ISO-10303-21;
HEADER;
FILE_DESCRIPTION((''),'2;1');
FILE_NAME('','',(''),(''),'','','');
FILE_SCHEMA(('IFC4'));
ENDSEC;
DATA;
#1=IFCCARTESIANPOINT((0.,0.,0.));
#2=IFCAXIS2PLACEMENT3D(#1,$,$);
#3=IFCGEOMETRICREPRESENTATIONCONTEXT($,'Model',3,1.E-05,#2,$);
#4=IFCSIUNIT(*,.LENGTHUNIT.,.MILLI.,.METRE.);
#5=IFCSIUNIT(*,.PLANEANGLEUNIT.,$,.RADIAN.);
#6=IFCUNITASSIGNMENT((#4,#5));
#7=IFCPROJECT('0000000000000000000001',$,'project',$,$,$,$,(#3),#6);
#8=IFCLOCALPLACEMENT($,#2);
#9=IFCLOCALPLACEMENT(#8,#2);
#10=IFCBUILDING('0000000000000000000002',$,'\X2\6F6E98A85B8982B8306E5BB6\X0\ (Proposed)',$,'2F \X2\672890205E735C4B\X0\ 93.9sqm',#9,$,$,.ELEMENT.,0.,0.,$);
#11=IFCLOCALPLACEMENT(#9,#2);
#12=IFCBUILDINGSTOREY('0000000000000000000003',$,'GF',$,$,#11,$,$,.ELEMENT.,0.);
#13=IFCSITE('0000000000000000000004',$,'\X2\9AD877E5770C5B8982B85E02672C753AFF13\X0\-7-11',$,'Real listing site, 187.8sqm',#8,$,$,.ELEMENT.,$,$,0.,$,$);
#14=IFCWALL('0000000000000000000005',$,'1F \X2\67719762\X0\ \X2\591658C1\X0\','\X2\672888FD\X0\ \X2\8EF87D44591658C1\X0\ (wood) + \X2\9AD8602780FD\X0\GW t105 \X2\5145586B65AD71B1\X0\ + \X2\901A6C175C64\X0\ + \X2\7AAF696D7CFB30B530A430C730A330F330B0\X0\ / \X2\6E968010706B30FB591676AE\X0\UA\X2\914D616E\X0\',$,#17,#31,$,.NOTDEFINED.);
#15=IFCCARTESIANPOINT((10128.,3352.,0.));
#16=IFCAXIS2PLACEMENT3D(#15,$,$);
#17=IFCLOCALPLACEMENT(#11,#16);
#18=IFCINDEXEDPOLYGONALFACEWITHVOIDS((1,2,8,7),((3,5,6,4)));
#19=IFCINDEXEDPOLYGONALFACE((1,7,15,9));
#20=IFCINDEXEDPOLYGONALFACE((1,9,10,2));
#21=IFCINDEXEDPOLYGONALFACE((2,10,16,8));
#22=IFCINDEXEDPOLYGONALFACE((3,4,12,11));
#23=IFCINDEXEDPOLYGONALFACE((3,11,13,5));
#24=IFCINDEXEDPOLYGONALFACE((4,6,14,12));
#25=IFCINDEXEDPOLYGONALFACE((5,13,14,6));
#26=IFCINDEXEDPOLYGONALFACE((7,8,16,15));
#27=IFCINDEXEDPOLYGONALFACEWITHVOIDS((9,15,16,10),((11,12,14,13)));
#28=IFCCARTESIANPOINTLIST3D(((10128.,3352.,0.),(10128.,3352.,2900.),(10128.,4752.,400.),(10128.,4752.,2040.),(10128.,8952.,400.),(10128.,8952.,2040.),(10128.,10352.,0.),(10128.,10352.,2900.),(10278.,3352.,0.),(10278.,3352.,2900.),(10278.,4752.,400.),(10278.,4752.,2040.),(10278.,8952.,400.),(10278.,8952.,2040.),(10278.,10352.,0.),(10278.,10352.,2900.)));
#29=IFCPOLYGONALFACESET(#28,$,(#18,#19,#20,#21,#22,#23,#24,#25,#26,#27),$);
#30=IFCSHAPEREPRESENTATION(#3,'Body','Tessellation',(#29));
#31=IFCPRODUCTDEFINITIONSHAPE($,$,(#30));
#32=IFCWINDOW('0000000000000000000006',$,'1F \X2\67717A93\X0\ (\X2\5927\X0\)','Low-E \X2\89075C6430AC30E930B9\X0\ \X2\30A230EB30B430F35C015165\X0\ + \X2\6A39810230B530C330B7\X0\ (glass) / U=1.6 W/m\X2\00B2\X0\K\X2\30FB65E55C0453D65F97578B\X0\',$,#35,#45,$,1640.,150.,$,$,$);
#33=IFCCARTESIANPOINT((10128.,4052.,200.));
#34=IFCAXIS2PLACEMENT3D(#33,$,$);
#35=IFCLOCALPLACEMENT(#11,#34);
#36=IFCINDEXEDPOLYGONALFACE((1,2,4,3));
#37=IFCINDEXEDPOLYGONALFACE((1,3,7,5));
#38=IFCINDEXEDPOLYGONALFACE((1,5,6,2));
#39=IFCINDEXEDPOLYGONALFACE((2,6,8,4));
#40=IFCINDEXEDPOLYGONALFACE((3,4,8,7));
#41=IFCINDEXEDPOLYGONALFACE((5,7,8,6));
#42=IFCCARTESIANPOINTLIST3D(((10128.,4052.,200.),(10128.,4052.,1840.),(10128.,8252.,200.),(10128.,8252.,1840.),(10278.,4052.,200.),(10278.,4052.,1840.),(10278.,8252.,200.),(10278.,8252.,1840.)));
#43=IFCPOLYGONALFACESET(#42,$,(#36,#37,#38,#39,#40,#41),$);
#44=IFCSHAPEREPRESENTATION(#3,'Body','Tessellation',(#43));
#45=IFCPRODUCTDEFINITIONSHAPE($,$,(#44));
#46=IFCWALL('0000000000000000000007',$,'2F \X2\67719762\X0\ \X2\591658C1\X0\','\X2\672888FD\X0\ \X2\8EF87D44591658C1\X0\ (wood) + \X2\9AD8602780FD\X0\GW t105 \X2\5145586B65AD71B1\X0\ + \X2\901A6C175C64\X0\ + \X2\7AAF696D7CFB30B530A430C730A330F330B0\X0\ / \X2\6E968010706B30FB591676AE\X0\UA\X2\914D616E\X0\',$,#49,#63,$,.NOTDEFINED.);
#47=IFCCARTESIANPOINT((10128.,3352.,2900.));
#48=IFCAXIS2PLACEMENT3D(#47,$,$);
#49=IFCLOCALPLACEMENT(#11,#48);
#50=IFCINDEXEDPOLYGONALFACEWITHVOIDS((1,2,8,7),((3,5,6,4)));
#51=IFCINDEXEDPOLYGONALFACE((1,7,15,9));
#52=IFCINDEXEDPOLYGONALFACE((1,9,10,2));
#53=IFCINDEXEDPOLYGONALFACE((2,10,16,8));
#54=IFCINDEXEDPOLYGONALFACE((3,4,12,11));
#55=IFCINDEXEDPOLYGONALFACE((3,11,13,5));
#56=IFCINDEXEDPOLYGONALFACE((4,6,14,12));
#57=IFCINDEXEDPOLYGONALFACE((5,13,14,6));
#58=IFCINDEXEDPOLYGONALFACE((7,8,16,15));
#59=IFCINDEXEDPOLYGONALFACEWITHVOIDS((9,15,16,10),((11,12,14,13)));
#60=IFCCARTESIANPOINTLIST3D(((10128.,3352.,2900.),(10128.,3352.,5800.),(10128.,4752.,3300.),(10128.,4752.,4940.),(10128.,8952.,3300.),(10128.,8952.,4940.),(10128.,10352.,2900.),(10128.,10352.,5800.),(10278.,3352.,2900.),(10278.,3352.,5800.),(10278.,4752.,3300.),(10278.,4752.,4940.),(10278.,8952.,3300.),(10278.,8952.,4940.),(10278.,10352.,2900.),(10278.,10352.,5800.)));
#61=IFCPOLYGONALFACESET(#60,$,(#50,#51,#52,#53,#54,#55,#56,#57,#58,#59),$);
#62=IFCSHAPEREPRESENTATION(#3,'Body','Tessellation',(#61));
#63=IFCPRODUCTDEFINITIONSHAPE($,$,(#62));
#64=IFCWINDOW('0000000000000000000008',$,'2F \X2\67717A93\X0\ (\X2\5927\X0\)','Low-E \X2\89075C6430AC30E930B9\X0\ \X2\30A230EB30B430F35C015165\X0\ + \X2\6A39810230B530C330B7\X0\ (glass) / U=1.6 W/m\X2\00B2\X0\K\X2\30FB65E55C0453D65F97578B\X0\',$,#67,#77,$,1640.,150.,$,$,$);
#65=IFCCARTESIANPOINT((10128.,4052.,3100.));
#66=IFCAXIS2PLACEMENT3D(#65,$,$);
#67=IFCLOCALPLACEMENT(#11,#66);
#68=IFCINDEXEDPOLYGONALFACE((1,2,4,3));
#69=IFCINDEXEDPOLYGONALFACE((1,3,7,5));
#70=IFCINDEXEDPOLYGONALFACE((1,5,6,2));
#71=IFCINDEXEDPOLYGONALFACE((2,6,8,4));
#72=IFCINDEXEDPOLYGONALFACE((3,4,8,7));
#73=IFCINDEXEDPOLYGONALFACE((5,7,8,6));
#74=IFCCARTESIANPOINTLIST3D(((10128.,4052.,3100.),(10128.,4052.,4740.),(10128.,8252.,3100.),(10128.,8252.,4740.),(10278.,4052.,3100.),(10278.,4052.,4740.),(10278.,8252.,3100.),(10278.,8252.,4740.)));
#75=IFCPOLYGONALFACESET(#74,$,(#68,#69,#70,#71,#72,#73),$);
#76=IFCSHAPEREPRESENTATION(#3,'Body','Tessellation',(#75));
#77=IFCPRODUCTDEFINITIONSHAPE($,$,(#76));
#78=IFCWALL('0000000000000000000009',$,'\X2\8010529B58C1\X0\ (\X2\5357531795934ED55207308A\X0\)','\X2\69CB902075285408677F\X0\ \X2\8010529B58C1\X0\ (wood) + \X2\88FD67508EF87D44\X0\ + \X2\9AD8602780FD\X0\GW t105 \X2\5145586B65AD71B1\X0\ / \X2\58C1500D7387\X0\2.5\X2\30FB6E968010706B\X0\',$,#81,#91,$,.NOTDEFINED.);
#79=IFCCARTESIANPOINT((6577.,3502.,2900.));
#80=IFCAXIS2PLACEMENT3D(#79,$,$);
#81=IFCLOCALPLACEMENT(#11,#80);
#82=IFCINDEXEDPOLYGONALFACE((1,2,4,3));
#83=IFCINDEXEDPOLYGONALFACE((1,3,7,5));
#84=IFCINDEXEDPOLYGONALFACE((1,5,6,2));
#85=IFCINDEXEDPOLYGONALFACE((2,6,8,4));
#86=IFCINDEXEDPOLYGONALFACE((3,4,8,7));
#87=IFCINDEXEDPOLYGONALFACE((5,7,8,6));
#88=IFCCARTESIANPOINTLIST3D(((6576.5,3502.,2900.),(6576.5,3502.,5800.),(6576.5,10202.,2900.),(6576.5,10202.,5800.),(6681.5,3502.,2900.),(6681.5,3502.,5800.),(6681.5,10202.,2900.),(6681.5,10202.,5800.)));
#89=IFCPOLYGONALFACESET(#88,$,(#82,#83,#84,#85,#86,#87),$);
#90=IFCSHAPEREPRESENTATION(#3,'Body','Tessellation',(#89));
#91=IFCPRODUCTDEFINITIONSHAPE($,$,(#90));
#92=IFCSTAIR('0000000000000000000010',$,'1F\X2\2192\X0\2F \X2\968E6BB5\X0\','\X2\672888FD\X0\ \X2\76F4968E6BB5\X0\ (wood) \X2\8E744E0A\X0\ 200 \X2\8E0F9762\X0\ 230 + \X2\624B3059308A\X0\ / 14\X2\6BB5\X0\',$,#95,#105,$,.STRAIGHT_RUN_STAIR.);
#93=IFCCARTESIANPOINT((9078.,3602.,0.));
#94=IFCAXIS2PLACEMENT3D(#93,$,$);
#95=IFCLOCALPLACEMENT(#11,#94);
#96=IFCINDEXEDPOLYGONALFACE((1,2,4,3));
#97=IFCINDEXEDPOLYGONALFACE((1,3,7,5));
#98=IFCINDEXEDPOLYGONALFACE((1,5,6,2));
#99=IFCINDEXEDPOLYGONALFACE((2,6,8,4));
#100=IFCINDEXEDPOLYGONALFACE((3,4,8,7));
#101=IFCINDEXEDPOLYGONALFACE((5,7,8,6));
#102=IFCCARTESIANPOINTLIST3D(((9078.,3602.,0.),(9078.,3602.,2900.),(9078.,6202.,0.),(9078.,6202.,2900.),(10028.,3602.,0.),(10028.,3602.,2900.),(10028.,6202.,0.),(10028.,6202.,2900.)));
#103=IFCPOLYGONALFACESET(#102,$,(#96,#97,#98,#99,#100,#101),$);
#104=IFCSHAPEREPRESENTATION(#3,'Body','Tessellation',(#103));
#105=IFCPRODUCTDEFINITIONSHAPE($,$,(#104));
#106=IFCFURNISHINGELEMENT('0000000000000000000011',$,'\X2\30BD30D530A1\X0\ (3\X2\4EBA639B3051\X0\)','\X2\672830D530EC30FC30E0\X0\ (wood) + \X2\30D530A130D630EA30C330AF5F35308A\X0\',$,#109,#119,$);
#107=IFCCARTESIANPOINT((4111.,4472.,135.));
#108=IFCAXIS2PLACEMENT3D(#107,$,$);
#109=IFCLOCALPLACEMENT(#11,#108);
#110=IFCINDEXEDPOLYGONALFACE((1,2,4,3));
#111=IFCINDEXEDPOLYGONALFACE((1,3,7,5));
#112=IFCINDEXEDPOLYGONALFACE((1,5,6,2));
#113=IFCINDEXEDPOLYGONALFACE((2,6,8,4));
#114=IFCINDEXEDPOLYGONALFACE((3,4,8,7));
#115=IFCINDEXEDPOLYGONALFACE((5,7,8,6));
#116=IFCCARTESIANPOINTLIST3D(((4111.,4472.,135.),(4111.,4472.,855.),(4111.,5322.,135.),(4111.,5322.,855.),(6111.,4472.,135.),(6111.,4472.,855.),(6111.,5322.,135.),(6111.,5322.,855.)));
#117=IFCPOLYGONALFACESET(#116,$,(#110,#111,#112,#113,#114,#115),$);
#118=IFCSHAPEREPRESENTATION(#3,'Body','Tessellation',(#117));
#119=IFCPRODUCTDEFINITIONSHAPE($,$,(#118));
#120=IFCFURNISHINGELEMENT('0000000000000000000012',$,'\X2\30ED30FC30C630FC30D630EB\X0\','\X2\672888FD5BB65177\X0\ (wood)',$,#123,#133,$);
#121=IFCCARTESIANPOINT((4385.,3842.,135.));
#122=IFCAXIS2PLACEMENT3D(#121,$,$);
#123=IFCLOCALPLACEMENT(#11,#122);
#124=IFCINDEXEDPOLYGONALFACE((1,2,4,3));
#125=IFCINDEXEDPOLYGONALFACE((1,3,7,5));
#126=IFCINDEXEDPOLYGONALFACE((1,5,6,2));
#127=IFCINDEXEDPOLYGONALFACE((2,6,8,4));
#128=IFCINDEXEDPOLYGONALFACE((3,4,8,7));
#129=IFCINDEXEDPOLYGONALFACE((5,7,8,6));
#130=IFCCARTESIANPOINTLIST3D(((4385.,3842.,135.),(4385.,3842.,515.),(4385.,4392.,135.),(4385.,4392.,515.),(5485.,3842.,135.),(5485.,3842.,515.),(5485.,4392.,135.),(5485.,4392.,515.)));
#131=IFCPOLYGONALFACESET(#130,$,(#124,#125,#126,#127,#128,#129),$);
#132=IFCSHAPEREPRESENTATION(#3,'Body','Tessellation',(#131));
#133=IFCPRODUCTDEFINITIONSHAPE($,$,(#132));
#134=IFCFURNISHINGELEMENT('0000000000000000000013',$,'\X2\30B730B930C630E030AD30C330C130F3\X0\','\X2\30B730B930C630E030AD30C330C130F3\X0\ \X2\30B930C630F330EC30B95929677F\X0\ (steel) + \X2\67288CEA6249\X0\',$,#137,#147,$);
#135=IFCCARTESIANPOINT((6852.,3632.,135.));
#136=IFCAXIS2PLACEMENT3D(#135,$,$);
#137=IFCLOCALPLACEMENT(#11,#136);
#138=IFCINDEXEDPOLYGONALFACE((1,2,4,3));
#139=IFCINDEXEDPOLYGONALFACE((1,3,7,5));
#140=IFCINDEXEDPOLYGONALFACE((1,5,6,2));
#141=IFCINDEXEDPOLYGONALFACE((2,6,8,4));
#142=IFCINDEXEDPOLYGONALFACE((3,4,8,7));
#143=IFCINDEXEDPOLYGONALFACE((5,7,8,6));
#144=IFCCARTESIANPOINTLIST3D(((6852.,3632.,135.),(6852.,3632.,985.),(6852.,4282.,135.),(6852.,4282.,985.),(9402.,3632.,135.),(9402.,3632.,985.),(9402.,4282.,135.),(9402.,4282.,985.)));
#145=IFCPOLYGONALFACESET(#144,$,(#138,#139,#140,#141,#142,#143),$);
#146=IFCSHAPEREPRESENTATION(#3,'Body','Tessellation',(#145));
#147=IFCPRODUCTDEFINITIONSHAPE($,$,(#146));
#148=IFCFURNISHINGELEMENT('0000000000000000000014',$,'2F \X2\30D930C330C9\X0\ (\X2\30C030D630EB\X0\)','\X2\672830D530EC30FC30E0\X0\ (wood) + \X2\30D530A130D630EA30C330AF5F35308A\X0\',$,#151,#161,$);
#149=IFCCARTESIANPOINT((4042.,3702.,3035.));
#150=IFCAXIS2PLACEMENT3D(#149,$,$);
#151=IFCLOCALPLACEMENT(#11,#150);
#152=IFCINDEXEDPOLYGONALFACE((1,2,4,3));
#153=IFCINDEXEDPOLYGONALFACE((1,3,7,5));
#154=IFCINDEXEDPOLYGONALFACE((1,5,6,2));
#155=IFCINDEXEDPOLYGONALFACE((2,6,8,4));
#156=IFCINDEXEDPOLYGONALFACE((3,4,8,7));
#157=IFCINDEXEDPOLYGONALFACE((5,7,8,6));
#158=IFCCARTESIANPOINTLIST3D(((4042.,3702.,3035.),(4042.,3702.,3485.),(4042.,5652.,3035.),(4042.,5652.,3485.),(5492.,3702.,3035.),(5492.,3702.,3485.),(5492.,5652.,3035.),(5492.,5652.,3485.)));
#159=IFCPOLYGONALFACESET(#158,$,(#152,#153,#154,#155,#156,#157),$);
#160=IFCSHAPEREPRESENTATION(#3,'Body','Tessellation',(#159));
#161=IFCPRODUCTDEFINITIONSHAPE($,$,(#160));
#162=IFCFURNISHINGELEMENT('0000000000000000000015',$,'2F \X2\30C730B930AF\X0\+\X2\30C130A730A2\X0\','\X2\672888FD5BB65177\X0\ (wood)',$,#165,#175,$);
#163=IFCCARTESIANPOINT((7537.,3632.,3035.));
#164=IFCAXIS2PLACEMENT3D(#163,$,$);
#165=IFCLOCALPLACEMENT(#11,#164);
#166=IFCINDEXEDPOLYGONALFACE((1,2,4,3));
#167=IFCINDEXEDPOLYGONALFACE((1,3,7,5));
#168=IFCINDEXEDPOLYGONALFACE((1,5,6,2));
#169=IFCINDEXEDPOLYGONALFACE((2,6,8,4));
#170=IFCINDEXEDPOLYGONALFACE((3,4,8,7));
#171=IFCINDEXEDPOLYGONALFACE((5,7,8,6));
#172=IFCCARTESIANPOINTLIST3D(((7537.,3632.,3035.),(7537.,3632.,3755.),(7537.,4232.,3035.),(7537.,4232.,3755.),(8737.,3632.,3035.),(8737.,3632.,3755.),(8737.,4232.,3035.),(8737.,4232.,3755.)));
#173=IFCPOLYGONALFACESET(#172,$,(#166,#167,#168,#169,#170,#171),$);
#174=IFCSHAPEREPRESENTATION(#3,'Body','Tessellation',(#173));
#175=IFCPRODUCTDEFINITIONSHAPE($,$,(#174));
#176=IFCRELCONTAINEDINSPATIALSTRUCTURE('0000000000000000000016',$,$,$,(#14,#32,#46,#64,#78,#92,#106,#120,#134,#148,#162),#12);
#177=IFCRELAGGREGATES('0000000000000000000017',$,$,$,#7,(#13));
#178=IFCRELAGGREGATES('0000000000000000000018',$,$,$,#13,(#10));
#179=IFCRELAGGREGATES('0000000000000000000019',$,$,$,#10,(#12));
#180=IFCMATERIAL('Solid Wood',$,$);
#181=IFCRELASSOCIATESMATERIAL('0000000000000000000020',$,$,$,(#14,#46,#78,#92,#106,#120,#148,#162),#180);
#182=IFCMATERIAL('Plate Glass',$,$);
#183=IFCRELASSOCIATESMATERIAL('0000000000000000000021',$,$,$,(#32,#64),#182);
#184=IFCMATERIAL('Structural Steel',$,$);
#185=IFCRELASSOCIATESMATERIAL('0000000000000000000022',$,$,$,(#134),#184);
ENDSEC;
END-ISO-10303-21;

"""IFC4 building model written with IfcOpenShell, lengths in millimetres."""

from ifc_helpers import new_model, si_unit, frame, frame_2d, origin, place, context, project, spatial, rectangle, extrude, material, element, fill, save


model = new_model("IFC4")

# Units and contexts
model_context = context("Model", 3, precision=1e-05, world=origin())
ifc_project = project(units=[si_unit("LENGTHUNIT", "METRE", prefix="MILLI"), si_unit("PLANEANGLEUNIT", "RADIAN")], contexts=[model_context])

# Site, building, storey
site_placement = place(None, origin())
site = spatial("IfcSite", under=ifc_project, at=site_placement, Name="高知県安芸市本町３-7-11", ObjectType="Real listing site, 187.8sqm", CompositionType="ELEMENT", RefElevation=0.0)
building_placement = place(site_placement, origin())
building = spatial("IfcBuilding", under=site, at=building_placement, Name="潮風安芸の家 (Proposed)", ObjectType="2F 木造平屋 93.9sqm", CompositionType="ELEMENT", ElevationOfRefHeight=0.0, ElevationOfTerrain=0.0)
storey_placement = place(building_placement, origin())
storey = spatial("IfcBuildingStorey", under=building, at=storey_placement, Name="GF", CompositionType="ELEMENT", Elevation=0.0)

# Wall, opening, window
ifc_material_1 = material(Name="Solid Wood")
wall_1_placement = place(storey_placement, frame((10128.0, 3352.0, 0.0)))
wall_1 = element("IfcWall", 1, at=wall_1_placement, inside=storey, material=ifc_material_1, Name="1F 東面 外壁", Description="木製 軸組外壁 (wood) + 高性能GW t105 充填断熱 + 通気層 + 窯業系サイディング / 準耐火・外皮UA配慮", PredefinedType="NOTDEFINED", context=model_context, shape_type="SweptSolid", body=[
    extrude(rectangle(XDim=150.0, YDim=7000.0, at=frame_2d((75.0, 3500.0))), frame((10128.0, 3352.0, 0.0)), (0.0, 0.0, 1.0), 2900.0),
])
opening_1_placement = place(storey_placement, frame((10128.0, 4052.0, 200.0)))
opening_1 = element("IfcOpeningElement", 2, at=opening_1_placement, cuts=wall_1, PredefinedType="NOTDEFINED", context=model_context, shape_type="SweptSolid", body=[
    extrude(rectangle(XDim=150.0, YDim=4200.0, at=frame_2d((75.0, 2100.0))), frame((10128.0, 4052.0, 200.0)), (0.0, 0.0, 1.0), 1640.0),
])
ifc_material_2 = material(Name="Plate Glass")
window_1_placement = place(storey_placement, frame((10128.0, 4052.0, 200.0)))
window_1 = element("IfcWindow", 3, at=window_1_placement, inside=storey, material=ifc_material_2, Name="1F 東窓 (大)", Description="Low-E 複層ガラス アルゴン封入 + 樹脂サッシ (glass) / U=1.6 W/m²K・日射取得型", OverallHeight=1640.0, OverallWidth=150.0, context=model_context, shape_type="SweptSolid", body=[
    extrude(rectangle(XDim=150.0, YDim=4200.0, at=frame_2d((75.0, 2100.0))), frame((10128.0, 4052.0, 200.0)), (0.0, 0.0, 1.0), 1640.0),
])
fill(opening_1, window_1)

# Wall, opening, window
wall_2_placement = place(storey_placement, frame((10128.0, 3352.0, 2900.0)))
wall_2 = element("IfcWall", 4, at=wall_2_placement, inside=storey, material=ifc_material_1, Name="2F 東面 外壁", Description="木製 軸組外壁 (wood) + 高性能GW t105 充填断熱 + 通気層 + 窯業系サイディング / 準耐火・外皮UA配慮", PredefinedType="NOTDEFINED", context=model_context, shape_type="SweptSolid", body=[
    extrude(rectangle(XDim=150.0, YDim=7000.0, at=frame_2d((75.0, 3500.0))), frame((10128.0, 3352.0, 2900.0)), (0.0, 0.0, 1.0), 2900.0),
])
opening_2_placement = place(storey_placement, frame((10128.0, 4052.0, 3100.0)))
opening_2 = element("IfcOpeningElement", 5, at=opening_2_placement, cuts=wall_2, PredefinedType="NOTDEFINED", context=model_context, shape_type="SweptSolid", body=[
    extrude(rectangle(XDim=150.0, YDim=4200.0, at=frame_2d((75.0, 2100.0))), frame((10128.0, 4052.0, 3100.0)), (0.0, 0.0, 1.0), 1640.0),
])
window_2_placement = place(storey_placement, frame((10128.0, 4052.0, 3100.0)))
window_2 = element("IfcWindow", 6, at=window_2_placement, inside=storey, material=ifc_material_2, Name="2F 東窓 (大)", Description="Low-E 複層ガラス アルゴン封入 + 樹脂サッシ (glass) / U=1.6 W/m²K・日射取得型", OverallHeight=1640.0, OverallWidth=150.0, context=model_context, shape_type="SweptSolid", body=[
    extrude(rectangle(XDim=150.0, YDim=4200.0, at=frame_2d((75.0, 2100.0))), frame((10128.0, 4052.0, 3100.0)), (0.0, 0.0, 1.0), 1640.0),
])
fill(opening_2, window_2)

# Wall
wall_3_placement = place(storey_placement, frame((6577.0, 3502.0, 2900.0)))
element("IfcWall", 7, at=wall_3_placement, inside=storey, material=ifc_material_1, Name="耐力壁 (南北間仕切り)", Description="構造用合板 耐力壁 (wood) + 製材軸組 + 高性能GW t105 充填断熱 / 壁倍率2.5・準耐火", PredefinedType="NOTDEFINED", context=model_context, shape_type="SweptSolid", body=[
    extrude(rectangle(XDim=105.0, YDim=6700.0, at=frame_2d((52.0, 3350.0))), frame((6577.0, 3502.0, 2900.0)), (0.0, 0.0, 1.0), 2900.0),
])

# Stair
stair_placement = place(storey_placement, frame((9078.0, 3602.0, 0.0)))
element("IfcStair", 8, at=stair_placement, inside=storey, material=ifc_material_1, Name="1F→2F 階段", Description="木製 直階段 (wood) 蹴上 200 踏面 230 + 手すり / 14段", PredefinedType="STRAIGHT_RUN_STAIR", context=model_context, shape_type="SweptSolid", body=[
    extrude(rectangle(XDim=950.0, YDim=2600.0, at=frame_2d((475.0, 1300.0))), frame((9078.0, 3602.0, 0.0)), (0.0, 0.0, 1.0), 2900.0),
])

# Furnishing elements
furnishing_1_placement = place(storey_placement, frame((4111.0, 4472.0, 135.0)))
element("IfcFurnishingElement", 9, at=furnishing_1_placement, inside=storey, material=ifc_material_1, Name="ソファ (3人掛け)", Description="木フレーム (wood) + ファブリック張り", context=model_context, shape_type="SweptSolid", body=[
    extrude(rectangle(XDim=2000.0, YDim=850.0, at=frame_2d((1000.0, 425.0))), frame((4111.0, 4472.0, 135.0)), (0.0, 0.0, 1.0), 720.0),
])
furnishing_2_placement = place(storey_placement, frame((4385.0, 3842.0, 135.0)))
element("IfcFurnishingElement", 10, at=furnishing_2_placement, inside=storey, material=ifc_material_1, Name="ローテーブル", Description="木製家具 (wood)", context=model_context, shape_type="SweptSolid", body=[
    extrude(rectangle(XDim=1100.0, YDim=550.0, at=frame_2d((550.0, 275.0))), frame((4385.0, 3842.0, 135.0)), (0.0, 0.0, 1.0), 380.0),
])
ifc_material_3 = material(Name="Structural Steel")
furnishing_3_placement = place(storey_placement, frame((6852.0, 3632.0, 135.0)))
element("IfcFurnishingElement", 11, at=furnishing_3_placement, inside=storey, material=ifc_material_3, Name="システムキッチン", Description="システムキッチン ステンレス天板 (steel) + 木質扉", context=model_context, shape_type="SweptSolid", body=[
    extrude(rectangle(XDim=2550.0, YDim=650.0, at=frame_2d((1275.0, 325.0))), frame((6852.0, 3632.0, 135.0)), (0.0, 0.0, 1.0), 850.0),
])
furnishing_4_placement = place(storey_placement, frame((4042.0, 3702.0, 3035.0)))
element("IfcFurnishingElement", 12, at=furnishing_4_placement, inside=storey, material=ifc_material_1, Name="2F ベッド (ダブル)", Description="木フレーム (wood) + ファブリック張り", context=model_context, shape_type="SweptSolid", body=[
    extrude(rectangle(XDim=1450.0, YDim=1950.0, at=frame_2d((725.0, 975.0))), frame((4042.0, 3702.0, 3035.0)), (0.0, 0.0, 1.0), 450.0),
])
furnishing_5_placement = place(storey_placement, frame((7537.0, 3632.0, 3035.0)))
element("IfcFurnishingElement", 13, at=furnishing_5_placement, inside=storey, material=ifc_material_1, Name="2F デスク+チェア", Description="木製家具 (wood)", context=model_context, shape_type="SweptSolid", body=[
    extrude(rectangle(XDim=1200.0, YDim=600.0, at=frame_2d((600.0, 300.0))), frame((7537.0, 3632.0, 3035.0)), (0.0, 0.0, 1.0), 720.0),
])

save(model, "model.ifc")
